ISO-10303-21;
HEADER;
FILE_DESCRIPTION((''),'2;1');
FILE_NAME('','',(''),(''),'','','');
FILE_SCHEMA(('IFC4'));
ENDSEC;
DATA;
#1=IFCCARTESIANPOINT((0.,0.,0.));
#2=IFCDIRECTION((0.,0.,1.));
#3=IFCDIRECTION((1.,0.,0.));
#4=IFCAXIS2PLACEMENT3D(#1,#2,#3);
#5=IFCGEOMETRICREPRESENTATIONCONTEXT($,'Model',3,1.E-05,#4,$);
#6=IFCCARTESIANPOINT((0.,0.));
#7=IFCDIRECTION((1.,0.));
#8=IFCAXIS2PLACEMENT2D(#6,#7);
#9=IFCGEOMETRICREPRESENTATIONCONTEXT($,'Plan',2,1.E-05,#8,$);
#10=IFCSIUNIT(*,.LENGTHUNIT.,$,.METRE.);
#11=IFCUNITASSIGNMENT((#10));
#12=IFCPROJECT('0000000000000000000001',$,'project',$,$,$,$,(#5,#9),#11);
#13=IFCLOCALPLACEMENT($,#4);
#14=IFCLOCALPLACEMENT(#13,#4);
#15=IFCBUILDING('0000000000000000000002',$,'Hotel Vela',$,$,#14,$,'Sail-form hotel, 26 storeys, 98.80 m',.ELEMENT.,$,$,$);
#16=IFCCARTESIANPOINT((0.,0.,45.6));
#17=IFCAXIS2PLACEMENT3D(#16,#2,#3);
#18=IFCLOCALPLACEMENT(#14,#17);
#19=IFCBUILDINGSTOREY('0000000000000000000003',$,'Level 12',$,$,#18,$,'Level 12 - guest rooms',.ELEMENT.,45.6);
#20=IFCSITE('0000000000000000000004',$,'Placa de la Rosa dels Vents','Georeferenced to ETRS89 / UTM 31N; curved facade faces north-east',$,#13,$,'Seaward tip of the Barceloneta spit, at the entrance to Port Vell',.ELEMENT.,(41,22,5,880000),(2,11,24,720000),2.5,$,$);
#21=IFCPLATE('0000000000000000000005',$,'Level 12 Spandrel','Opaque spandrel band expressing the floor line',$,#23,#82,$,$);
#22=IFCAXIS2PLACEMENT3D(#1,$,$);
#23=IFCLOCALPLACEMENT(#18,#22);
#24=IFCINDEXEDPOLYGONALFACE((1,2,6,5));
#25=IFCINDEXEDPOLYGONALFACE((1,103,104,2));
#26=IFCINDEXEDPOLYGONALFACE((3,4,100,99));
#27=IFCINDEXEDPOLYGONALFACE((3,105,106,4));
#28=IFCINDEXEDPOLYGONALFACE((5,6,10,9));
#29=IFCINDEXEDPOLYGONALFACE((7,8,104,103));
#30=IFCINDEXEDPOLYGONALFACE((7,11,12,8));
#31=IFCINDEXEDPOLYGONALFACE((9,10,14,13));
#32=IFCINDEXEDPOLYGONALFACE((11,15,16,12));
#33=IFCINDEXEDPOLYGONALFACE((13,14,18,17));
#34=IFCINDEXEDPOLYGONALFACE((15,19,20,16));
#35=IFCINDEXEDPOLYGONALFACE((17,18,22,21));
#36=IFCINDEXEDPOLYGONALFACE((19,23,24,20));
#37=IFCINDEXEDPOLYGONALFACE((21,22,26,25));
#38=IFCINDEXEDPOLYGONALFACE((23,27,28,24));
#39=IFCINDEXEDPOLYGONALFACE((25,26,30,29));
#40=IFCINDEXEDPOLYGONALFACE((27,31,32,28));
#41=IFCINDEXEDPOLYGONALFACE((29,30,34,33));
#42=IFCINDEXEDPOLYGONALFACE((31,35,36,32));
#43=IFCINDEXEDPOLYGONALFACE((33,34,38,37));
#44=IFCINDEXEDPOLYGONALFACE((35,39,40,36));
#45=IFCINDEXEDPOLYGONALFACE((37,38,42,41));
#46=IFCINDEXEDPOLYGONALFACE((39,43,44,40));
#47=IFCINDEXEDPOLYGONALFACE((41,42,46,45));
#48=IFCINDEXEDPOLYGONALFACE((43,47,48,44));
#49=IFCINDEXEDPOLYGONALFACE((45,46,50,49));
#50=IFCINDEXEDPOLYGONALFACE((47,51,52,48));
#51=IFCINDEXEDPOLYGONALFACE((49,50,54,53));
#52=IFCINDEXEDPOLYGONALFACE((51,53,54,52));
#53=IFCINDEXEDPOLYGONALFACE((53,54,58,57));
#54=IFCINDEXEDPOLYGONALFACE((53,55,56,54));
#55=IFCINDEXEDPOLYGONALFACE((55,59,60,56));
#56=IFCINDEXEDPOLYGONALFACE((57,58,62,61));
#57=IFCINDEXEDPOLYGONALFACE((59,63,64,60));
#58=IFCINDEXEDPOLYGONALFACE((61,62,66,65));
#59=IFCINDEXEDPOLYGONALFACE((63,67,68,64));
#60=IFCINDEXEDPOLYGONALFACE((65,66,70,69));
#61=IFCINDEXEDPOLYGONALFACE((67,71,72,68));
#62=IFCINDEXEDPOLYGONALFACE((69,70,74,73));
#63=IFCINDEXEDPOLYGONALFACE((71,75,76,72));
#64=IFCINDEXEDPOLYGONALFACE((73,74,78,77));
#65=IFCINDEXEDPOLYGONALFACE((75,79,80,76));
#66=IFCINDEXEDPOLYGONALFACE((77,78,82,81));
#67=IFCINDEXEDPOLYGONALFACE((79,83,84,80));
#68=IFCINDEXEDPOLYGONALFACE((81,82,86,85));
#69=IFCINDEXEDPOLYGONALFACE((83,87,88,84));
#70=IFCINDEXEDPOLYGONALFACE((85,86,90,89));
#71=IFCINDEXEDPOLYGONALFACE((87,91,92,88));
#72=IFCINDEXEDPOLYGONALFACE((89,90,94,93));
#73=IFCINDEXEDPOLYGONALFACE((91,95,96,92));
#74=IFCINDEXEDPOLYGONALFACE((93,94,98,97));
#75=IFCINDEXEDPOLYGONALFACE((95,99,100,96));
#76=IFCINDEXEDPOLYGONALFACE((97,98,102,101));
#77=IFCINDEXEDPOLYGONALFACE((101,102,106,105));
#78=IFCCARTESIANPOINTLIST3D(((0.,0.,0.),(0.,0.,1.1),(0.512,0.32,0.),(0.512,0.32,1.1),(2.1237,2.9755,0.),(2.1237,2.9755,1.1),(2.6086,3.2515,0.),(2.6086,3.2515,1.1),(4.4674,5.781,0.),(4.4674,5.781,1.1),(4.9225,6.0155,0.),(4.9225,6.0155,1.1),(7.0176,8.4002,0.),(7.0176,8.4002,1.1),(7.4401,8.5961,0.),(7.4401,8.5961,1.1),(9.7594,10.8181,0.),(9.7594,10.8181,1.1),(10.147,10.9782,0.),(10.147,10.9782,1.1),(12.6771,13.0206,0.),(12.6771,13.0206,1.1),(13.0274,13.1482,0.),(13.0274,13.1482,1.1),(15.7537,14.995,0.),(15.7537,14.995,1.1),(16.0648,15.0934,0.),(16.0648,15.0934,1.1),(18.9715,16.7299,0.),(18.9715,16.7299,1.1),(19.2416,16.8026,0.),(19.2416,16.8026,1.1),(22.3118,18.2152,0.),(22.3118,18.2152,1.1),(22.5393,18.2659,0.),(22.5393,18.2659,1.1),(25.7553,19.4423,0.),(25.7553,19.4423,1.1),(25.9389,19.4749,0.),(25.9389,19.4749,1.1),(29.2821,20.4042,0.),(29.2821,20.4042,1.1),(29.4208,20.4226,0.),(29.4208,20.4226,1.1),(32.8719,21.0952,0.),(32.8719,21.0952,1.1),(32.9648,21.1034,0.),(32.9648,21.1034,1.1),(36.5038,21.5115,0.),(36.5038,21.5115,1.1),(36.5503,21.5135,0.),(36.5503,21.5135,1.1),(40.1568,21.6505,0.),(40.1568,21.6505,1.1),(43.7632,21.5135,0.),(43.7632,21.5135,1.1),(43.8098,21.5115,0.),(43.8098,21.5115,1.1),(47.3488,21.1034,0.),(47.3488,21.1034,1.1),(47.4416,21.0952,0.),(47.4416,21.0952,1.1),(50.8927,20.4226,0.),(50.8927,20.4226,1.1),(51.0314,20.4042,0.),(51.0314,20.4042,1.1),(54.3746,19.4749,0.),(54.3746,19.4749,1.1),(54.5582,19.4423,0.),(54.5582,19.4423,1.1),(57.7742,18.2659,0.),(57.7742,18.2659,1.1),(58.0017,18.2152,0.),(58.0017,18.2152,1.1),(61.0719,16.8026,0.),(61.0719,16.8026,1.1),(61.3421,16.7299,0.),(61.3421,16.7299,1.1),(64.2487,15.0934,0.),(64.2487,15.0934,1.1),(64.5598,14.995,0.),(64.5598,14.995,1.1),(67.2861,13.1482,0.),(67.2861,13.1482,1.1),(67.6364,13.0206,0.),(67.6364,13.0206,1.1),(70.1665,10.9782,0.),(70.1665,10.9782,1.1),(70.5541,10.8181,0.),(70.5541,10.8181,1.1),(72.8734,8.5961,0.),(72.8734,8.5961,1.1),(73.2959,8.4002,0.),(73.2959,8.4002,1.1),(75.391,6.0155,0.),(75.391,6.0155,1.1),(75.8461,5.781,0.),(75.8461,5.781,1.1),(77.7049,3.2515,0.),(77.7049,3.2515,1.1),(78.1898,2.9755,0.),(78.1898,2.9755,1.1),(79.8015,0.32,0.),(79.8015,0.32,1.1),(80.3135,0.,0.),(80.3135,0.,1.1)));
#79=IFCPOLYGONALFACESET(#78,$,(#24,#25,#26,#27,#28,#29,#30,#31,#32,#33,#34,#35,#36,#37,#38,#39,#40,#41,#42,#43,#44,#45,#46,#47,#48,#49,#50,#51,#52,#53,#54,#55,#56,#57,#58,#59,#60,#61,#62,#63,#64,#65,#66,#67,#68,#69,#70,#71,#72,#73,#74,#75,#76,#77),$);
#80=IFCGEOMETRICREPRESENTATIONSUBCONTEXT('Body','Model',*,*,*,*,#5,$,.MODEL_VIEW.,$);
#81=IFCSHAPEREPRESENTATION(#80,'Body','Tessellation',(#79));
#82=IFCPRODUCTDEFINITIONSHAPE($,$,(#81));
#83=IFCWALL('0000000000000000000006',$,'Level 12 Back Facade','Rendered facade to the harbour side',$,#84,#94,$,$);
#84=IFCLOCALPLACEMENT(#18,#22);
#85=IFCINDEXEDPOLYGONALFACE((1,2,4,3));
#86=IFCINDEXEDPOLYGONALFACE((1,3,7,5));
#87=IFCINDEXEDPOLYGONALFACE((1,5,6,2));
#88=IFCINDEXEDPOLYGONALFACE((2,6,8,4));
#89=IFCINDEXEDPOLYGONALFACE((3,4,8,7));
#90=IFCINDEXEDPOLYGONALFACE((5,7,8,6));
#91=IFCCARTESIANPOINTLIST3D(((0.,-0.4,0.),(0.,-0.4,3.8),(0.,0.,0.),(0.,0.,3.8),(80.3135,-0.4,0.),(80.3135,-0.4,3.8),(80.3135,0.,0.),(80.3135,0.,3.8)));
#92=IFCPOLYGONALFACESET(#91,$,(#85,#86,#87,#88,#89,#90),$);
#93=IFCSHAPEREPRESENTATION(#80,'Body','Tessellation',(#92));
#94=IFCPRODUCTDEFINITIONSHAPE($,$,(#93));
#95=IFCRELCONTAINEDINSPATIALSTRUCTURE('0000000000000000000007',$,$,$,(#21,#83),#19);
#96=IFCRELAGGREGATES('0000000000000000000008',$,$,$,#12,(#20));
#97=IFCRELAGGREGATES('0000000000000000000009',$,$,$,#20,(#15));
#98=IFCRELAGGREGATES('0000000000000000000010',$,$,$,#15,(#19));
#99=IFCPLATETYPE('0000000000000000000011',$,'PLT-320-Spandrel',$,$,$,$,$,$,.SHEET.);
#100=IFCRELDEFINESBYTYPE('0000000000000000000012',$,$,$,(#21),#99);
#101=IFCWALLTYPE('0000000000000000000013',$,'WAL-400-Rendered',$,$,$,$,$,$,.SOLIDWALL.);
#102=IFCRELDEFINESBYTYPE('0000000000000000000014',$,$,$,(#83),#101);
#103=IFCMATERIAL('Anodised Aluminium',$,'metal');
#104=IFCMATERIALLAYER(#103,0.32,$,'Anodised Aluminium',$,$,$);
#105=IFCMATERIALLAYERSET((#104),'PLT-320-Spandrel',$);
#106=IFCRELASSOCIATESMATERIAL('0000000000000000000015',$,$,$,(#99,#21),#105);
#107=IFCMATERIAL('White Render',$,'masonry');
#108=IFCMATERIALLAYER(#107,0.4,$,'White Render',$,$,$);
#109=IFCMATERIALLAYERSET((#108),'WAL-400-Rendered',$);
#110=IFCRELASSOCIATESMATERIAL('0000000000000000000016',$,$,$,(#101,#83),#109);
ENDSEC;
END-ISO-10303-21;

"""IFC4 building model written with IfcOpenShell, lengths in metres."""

from ifc_helpers import new_model, si_unit, frame, origin_with_axes, origin_2d_with_axis, place, context, subcontext, project, spatial, line, indexed_curve, outline, extrude, material, layer, layer_set, layer_usage, type_object, element, save


model = new_model("IFC4")

# Units and contexts
model_context = context("Model", 3, precision=1e-05, world=origin_with_axes())
plan_context = context("Plan", 2, precision=1e-05, world=origin_2d_with_axis())
body_context = subcontext(model_context, "Body", "Model", "MODEL_VIEW")
ifc_project = project(units=[si_unit("LENGTHUNIT", "METRE")], contexts=[model_context, plan_context])

# Site, building, storey
site_placement = place(None, origin_with_axes())
site = spatial("IfcSite", under=ifc_project, at=site_placement, Name="Placa de la Rosa dels Vents", Description="Georeferenced to ETRS89 / UTM 31N; curved facade faces north-east", LongName="Seaward tip of the Barceloneta spit, at the entrance to Port Vell", CompositionType="ELEMENT", RefLatitude=(41, 22, 5, 880000), RefLongitude=(2, 11, 24, 720000), RefElevation=2.5)
building_placement = place(site_placement, origin_with_axes())
building = spatial("IfcBuilding", under=site, at=building_placement, Name="Hotel Vela", LongName="Sail-form hotel, 26 storeys, 98.80 m", CompositionType="ELEMENT")
storey_placement = place(building_placement, frame((0.0, 0.0, 45.6), z_axis=(0.0, 0.0, 1.0), x_axis=(1.0, 0.0, 0.0)))
storey = spatial("IfcBuildingStorey", under=building, at=storey_placement, Name="Level 12", LongName="Level 12 - guest rooms", CompositionType="ELEMENT", Elevation=45.6)

# Plate
ifc_material_1 = material(Name="Anodised Aluminium", Category="metal")
ifc_layer_1 = layer(ifc_material_1, 0.32, Name="Anodised Aluminium")
ifc_layer_set_1 = layer_set([ifc_layer_1], Name="PLT-320-Spandrel")
ifc_layer_usage_1 = layer_usage(ifc_layer_set_1, "AXIS2", "POSITIVE", 0.0)
plate_type_1 = type_object("IfcPlateType", Name="PLT-320-Spandrel", PredefinedType="SHEET", material=ifc_layer_set_1)
plate_1_placement = place(storey_placement, origin_with_axes())
element("IfcPlate", 1, at=plate_1_placement, inside=storey, type_object=plate_type_1, material=ifc_layer_usage_1, Name="Level 12 Spandrel", Description="Opaque spandrel band expressing the floor line", context=body_context, shape_type="SweptSolid", body=[
    extrude(outline(indexed_curve([(80.3135, 0.0), (78.1898, 2.9755), (75.8461, 5.781), (73.2959, 8.4002), (70.5541, 10.8181), (67.6364, 13.0206), (64.5598, 14.995), (61.3421, 16.7299), (58.0017, 18.2152), (54.5582, 19.4423), (51.0314, 20.4042), (47.4416, 21.0952), (43.8098, 21.5115), (40.1568, 21.6505), (36.5038, 21.5115), (32.8719, 21.0952), (29.2821, 20.4042), (25.7553, 19.4423), (22.3118, 18.2152), (18.9715, 16.7299), (15.7537, 14.995), (12.6771, 13.0206), (9.7594, 10.8181), (7.0176, 8.4002), (4.4674, 5.781), (2.1237, 2.9755), (0.0, 0.0), (79.8015, 0.32), (2.6086, 3.2515), (4.9225, 6.0155), (7.4401, 8.5961), (10.147, 10.9782), (13.0274, 13.1482), (16.0648, 15.0934), (19.2416, 16.8026), (22.5393, 18.2659), (25.9389, 19.4749), (29.4208, 20.4226), (32.9648, 21.1034), (36.5503, 21.5135), (40.1568, 21.6505), (43.7632, 21.5135), (47.3488, 21.1034), (50.8927, 20.4226), (54.3746, 19.4749), (57.7742, 18.2659), (61.0719, 16.8026), (64.2487, 15.0934), (67.2861, 13.1482), (70.1665, 10.9782), (72.8734, 8.5961), (75.391, 6.0155), (77.7049, 3.2515), (0.512, 0.32)], segments=[line(1, 2, 3, 4, 5, 6, 7, 8, 9, 10, 11, 12, 13, 14, 15, 16, 17, 18, 19, 20, 21, 22, 23, 24, 25, 26, 27, 28, 29, 30, 31, 32, 33, 34, 35, 36, 37, 38, 39, 40, 41, 42, 43, 44, 45, 46, 47, 48, 49, 50, 51, 52, 53, 54, 1)])), origin_with_axes(), (0.0, 0.0, 1.0), 1.1),
])

# Wall
ifc_material_2 = material(Name="White Render", Category="masonry")
ifc_layer_2 = layer(ifc_material_2, 0.4, Name="White Render")
ifc_layer_set_2 = layer_set([ifc_layer_2], Name="WAL-400-Rendered")
ifc_layer_usage_2 = layer_usage(ifc_layer_set_2, "AXIS2", "POSITIVE", 0.0)
wall_type = type_object("IfcWallType", Name="WAL-400-Rendered", PredefinedType="SOLIDWALL", material=ifc_layer_set_2)
wall_placement = place(storey_placement, frame((0.0, -0.4, 0.0), z_axis=(0.0, 0.0, 1.0), x_axis=(1.0, 0.0, 0.0)))
element("IfcWall", 2, at=wall_placement, inside=storey, type_object=wall_type, material=ifc_layer_usage_2, Name="Level 12 Back Facade", Description="Rendered facade to the harbour side", context=body_context, shape_type="SweptSolid", body=[
    extrude(outline(indexed_curve([(0.0, 0.0), (80.3135, 0.0), (80.3135, 0.4), (0.0, 0.4)], segments=[line(1, 2, 3, 4, 1)])), origin_with_axes(), (0.0, 0.0, 1.0), 3.8),
])

save(model, "model.ifc")
